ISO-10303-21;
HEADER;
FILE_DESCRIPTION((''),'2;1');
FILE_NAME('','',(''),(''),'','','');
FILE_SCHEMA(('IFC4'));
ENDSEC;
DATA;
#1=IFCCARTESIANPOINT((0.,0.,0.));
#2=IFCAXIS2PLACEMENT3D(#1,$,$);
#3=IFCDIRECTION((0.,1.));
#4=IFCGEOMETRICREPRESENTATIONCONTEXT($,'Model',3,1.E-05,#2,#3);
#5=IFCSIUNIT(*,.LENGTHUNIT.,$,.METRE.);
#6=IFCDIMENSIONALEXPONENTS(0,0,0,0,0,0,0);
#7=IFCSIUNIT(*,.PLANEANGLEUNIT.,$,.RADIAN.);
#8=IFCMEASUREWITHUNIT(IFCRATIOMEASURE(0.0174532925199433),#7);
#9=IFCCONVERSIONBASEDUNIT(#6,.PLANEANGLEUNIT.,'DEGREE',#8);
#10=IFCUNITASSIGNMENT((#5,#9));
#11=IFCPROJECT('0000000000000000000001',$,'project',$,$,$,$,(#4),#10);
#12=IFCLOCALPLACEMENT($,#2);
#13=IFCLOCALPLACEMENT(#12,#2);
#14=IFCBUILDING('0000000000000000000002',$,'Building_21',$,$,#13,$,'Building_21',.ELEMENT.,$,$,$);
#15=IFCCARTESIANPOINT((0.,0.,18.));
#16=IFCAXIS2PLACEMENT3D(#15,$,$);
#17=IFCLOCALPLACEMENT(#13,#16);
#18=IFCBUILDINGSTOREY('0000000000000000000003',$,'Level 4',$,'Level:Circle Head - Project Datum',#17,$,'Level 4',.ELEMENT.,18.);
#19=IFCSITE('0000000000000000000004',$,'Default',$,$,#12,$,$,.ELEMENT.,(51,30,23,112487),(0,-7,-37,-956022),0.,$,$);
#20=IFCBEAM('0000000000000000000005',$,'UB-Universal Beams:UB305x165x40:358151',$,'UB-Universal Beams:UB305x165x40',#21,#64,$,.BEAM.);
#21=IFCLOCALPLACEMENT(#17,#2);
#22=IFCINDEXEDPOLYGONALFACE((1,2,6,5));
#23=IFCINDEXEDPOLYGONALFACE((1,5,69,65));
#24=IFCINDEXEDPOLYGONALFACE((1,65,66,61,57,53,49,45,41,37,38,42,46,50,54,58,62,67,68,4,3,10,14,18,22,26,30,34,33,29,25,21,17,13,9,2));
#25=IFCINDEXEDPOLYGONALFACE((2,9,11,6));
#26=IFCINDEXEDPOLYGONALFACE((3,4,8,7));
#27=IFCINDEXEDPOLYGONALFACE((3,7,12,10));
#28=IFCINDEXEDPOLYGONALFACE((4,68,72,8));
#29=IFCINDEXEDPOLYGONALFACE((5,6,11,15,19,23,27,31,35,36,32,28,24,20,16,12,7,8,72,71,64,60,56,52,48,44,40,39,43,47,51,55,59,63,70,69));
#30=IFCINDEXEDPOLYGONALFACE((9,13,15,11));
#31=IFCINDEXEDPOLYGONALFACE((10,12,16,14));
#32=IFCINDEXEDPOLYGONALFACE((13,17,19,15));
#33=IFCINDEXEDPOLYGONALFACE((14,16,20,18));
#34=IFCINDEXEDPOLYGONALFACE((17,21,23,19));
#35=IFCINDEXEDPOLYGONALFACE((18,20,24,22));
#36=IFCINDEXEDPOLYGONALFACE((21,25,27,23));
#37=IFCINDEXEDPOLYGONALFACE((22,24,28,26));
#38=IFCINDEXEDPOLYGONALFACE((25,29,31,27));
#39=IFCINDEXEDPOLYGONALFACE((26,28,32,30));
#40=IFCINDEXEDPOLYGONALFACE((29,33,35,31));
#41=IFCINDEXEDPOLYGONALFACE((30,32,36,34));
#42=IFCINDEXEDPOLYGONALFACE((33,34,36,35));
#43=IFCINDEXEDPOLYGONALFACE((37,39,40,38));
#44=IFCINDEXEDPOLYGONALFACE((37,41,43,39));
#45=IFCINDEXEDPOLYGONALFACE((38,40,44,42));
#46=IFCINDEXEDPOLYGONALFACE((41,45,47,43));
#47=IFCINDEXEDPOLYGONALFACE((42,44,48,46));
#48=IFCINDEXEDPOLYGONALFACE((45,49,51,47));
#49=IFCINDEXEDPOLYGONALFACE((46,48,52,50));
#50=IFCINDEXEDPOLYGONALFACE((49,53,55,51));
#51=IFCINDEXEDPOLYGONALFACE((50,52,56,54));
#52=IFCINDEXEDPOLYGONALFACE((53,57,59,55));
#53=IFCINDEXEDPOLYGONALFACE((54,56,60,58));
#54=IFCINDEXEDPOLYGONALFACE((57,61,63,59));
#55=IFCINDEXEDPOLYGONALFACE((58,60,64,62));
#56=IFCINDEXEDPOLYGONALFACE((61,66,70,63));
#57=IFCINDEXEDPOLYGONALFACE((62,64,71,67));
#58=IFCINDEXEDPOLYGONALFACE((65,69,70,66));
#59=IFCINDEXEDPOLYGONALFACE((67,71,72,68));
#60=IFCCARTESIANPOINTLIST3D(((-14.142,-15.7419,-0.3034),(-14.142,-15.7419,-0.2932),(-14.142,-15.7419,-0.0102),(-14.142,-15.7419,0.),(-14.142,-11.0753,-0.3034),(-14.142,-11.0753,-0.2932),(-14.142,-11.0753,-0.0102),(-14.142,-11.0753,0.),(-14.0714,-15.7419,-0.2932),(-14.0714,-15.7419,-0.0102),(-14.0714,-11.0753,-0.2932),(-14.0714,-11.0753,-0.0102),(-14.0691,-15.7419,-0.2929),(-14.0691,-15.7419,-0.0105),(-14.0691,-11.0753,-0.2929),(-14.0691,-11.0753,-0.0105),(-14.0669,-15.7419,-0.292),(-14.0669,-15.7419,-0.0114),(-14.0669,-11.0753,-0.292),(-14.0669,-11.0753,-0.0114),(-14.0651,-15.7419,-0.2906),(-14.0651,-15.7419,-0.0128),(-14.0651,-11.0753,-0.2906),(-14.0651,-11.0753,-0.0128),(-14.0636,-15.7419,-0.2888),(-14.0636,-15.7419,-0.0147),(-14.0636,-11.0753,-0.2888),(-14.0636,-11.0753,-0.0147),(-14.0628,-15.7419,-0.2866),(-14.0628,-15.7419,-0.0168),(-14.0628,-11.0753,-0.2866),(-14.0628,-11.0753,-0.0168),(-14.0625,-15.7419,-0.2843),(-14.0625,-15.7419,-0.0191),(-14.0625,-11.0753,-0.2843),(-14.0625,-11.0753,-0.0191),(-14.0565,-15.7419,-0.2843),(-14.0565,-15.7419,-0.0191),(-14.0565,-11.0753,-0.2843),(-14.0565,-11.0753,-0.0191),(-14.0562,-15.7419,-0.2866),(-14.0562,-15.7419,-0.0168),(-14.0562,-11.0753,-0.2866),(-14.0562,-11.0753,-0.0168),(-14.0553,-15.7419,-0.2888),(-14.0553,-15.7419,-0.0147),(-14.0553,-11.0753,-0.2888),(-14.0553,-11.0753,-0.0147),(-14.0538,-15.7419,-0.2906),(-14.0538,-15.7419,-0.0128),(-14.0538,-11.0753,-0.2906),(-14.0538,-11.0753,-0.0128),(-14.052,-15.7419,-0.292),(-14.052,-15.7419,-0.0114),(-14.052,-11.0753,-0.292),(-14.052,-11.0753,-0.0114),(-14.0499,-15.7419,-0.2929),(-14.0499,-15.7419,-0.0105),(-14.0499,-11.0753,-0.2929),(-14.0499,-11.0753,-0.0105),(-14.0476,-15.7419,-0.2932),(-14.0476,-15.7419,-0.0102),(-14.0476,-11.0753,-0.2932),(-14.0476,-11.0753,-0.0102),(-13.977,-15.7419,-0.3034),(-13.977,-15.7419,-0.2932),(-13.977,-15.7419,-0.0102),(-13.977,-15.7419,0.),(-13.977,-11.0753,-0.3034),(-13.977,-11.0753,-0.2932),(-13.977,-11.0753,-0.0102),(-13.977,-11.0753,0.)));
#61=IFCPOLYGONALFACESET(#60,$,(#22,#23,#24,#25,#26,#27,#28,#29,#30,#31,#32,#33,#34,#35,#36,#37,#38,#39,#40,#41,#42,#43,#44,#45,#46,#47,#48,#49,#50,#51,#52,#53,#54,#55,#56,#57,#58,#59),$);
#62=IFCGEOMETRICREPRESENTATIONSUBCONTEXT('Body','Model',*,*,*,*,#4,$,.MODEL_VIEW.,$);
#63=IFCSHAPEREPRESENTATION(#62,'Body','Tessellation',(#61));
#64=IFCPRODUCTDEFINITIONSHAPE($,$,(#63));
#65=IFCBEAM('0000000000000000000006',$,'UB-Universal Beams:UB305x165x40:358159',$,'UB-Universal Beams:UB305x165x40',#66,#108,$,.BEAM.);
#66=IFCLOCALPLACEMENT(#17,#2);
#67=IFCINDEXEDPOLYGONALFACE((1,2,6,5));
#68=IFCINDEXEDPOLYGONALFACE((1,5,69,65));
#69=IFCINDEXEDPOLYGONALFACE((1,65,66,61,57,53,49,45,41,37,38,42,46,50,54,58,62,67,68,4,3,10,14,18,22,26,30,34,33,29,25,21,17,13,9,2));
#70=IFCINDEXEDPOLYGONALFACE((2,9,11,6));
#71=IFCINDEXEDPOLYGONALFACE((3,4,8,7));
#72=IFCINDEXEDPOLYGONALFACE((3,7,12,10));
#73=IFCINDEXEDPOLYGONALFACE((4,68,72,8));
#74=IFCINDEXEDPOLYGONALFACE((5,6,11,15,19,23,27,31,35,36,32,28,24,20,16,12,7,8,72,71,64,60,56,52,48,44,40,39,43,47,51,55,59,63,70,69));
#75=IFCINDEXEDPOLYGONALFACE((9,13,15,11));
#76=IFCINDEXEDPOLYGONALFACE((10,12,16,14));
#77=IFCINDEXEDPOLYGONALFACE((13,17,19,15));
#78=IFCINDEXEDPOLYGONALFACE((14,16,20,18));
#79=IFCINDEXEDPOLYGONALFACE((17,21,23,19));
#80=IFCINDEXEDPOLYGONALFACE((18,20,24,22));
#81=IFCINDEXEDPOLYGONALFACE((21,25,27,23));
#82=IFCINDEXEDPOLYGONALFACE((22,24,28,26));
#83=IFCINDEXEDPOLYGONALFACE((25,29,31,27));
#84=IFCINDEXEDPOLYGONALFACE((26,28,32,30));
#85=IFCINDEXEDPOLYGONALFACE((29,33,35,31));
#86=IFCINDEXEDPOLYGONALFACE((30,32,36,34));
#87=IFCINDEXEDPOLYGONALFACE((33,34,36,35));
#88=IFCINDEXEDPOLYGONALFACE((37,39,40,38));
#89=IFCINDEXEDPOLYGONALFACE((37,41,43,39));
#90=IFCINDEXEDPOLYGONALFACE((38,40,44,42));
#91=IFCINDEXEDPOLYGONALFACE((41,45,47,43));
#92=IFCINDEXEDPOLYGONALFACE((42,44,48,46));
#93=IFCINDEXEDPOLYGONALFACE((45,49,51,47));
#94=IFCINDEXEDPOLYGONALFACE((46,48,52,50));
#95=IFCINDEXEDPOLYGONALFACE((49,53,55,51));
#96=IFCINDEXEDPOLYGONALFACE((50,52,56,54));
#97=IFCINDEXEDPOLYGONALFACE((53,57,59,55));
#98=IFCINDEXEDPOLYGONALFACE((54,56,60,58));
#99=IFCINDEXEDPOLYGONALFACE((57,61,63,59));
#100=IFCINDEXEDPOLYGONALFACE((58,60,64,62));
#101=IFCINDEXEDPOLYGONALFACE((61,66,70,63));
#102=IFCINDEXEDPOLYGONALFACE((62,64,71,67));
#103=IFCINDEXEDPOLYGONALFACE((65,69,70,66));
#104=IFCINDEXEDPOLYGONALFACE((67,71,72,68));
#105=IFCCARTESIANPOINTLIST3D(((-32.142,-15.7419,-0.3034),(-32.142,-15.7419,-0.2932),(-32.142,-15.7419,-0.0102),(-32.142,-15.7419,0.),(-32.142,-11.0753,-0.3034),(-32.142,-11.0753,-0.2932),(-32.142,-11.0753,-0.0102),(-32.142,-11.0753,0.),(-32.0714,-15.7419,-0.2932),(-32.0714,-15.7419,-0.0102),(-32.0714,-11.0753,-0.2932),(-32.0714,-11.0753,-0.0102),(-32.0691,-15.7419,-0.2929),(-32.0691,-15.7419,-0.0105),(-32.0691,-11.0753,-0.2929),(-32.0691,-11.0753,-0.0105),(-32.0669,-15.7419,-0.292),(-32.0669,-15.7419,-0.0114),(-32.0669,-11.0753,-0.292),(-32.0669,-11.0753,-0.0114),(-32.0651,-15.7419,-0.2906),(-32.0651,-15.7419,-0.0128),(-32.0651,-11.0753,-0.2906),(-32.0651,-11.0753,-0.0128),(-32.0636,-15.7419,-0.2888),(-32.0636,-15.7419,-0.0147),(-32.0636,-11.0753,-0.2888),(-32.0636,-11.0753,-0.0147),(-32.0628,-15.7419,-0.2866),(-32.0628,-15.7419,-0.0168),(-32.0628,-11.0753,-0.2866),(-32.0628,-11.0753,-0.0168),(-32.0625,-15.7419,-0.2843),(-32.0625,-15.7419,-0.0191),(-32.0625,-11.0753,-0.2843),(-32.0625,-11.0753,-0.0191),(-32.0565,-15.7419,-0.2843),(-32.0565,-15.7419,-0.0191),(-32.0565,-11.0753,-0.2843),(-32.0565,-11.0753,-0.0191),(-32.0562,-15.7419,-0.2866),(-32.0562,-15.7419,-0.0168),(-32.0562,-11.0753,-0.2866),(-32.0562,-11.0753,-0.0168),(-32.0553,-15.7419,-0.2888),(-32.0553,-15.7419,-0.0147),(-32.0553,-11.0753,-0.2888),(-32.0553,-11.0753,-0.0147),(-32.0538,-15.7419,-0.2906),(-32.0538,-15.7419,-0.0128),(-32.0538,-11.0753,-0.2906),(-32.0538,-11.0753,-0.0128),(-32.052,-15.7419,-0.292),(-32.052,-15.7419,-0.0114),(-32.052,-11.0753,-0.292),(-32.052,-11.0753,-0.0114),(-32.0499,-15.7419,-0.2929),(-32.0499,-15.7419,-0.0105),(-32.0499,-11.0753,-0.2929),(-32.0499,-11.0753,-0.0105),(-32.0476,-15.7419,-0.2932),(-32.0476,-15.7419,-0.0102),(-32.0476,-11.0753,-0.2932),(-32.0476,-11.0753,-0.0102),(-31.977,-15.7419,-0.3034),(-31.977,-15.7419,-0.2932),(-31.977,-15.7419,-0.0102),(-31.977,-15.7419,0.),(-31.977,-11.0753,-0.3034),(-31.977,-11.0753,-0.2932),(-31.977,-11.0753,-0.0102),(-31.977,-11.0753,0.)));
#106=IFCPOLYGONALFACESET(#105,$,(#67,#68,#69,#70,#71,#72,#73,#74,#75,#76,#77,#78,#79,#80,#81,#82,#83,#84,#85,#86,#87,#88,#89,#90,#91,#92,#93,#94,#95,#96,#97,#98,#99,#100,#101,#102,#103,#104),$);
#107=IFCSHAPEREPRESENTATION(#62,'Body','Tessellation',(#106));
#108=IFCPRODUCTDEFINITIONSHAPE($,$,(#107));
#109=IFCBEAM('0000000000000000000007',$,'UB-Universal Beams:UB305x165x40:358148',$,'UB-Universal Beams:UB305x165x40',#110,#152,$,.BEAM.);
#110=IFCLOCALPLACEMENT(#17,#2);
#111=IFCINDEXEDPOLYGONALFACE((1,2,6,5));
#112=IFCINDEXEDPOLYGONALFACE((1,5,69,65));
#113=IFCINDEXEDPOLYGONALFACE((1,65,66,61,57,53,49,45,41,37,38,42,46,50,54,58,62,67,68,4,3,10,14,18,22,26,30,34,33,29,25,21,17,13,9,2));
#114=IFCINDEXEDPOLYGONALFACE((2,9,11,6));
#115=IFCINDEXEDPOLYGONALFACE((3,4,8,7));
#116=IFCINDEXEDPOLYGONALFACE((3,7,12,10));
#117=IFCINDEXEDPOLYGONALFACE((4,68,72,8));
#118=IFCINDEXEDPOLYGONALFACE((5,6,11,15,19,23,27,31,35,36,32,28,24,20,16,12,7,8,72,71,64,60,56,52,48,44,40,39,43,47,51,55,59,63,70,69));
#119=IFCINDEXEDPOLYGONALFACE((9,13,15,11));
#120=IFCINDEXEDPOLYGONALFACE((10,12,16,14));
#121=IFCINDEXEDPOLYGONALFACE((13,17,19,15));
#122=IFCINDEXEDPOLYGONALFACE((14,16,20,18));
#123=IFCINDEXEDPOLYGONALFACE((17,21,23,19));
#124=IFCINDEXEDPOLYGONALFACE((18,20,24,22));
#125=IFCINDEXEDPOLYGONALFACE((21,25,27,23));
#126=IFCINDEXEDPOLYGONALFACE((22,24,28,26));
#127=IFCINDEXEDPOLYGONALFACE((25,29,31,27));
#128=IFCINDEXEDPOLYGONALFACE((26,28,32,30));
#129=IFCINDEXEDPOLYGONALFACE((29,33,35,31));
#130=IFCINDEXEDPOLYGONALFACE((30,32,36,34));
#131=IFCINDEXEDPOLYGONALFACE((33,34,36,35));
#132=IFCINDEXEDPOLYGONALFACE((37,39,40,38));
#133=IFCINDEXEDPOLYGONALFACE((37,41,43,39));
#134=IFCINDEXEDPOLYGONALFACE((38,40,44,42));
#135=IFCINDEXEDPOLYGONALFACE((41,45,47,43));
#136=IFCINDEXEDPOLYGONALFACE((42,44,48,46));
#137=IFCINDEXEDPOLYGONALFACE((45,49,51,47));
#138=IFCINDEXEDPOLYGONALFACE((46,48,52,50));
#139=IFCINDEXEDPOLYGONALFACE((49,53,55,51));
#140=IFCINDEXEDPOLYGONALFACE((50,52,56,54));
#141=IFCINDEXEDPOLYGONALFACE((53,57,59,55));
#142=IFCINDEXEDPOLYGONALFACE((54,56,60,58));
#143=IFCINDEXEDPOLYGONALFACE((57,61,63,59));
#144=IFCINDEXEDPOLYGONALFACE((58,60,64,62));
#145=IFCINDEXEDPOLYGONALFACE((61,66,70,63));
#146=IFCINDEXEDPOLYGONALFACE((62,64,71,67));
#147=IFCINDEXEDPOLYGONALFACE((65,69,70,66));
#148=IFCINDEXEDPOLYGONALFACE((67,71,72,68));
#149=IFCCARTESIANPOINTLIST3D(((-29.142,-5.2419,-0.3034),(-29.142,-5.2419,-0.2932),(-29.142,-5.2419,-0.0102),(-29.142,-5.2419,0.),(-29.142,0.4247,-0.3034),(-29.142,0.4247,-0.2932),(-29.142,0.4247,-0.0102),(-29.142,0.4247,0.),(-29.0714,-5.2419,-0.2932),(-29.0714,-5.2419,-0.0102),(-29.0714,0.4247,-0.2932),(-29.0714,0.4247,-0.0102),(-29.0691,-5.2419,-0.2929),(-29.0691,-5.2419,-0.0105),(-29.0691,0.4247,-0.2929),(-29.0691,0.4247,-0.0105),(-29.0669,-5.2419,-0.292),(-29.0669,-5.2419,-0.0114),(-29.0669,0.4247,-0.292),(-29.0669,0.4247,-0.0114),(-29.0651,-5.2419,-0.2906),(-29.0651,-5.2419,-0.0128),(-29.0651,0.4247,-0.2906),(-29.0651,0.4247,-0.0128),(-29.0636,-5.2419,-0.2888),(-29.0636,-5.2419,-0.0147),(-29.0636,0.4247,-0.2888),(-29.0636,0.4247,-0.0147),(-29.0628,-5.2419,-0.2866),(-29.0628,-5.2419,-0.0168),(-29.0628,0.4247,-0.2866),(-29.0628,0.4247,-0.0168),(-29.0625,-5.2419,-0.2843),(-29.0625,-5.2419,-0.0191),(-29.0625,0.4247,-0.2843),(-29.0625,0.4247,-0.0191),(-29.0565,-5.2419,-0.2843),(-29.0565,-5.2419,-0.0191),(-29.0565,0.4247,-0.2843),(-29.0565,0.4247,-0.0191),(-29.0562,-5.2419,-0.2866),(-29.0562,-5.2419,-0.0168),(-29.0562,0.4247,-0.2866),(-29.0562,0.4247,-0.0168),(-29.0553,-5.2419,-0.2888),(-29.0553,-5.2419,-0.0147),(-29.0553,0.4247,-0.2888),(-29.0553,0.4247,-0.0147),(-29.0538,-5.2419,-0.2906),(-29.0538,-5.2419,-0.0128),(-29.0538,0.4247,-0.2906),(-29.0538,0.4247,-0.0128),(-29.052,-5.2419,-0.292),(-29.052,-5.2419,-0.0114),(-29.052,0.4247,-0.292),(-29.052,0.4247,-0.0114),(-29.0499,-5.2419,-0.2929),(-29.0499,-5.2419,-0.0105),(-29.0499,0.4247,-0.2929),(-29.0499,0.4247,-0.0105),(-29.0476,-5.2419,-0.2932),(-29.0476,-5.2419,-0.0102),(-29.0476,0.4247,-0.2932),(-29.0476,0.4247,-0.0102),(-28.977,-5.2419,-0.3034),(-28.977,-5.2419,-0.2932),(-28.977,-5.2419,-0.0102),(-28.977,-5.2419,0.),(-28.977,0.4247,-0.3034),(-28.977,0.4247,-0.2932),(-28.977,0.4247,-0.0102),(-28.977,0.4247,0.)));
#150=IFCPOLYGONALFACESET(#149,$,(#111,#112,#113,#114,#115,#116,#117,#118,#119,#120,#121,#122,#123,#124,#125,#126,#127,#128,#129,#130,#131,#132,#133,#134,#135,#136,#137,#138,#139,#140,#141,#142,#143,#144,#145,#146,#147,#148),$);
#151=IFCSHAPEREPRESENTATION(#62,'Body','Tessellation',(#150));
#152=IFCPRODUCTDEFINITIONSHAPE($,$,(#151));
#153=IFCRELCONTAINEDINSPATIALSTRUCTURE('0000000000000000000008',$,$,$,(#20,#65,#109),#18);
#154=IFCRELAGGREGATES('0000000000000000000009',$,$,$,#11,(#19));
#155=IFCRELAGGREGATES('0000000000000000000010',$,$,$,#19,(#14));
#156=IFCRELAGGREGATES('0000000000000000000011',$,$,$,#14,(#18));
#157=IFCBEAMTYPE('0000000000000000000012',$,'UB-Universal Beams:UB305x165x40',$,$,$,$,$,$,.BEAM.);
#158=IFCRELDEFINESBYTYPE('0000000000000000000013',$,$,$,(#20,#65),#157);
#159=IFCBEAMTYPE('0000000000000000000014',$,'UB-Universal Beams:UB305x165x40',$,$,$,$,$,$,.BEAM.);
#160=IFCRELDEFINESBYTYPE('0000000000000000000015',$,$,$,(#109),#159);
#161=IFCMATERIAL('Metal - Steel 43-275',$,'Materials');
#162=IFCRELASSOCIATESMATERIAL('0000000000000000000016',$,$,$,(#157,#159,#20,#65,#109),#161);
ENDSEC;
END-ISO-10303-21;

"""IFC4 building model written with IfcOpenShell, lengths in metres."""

from ifc_helpers import new_model, entity, si_unit, converted_unit, direction, frame, frame_2d, origin, place, context, subcontext, project, spatial, polyline, circle_curve, parameter, trimmed, segment, composite_curve, i_section, outline, extrude, source, transform, mapped, material, material_profile, profile_set, profile_usage, type_object, type_shapes, element, save


model = new_model("IFC4")

# Units and contexts
model_context = context("Model", 3, precision=1e-05, world=origin(), true_north=direction((0.0, 1.0)))
body_context = subcontext(model_context, "Body", "Model", "MODEL_VIEW")
ifc_project = project(units=[si_unit("LENGTHUNIT", "METRE"), converted_unit("PLANEANGLEUNIT", "DEGREE", entity("IfcRatioMeasure", 0.0174532925199433), si_unit("PLANEANGLEUNIT", "RADIAN"), dimensions=[0, 0, 0, 0, 0, 0, 0])], contexts=[model_context])

# Site, building, storey
site_placement = place(None, origin())
site = spatial("IfcSite", under=ifc_project, at=site_placement, Name="Default", CompositionType="ELEMENT", RefLatitude=(51, 30, 23, 112487), RefLongitude=(0, -7, -37, -956022), RefElevation=0.0)
building_placement = place(site_placement, origin())
building = spatial("IfcBuilding", under=site, at=building_placement, Name="Building_21", LongName="Building_21", CompositionType="ELEMENT")
storey_placement = place(building_placement, frame((0.0, 0.0, 18.0)))
storey = spatial("IfcBuildingStorey", under=building, at=storey_placement, Name="Level 4", ObjectType="Level:Circle Head - Project Datum", LongName="Level 4", CompositionType="ELEMENT", Elevation=18.0)

# Beams
ifc_material_1 = material(Name="Metal - Steel 43-275", Category="Materials")
ifc_material_profile_1 = material_profile(ifc_material_1, outline(composite_curve([segment(polyline([(0.0119, -0.1415, 0.0), (0.0825, -0.1415, 0.0)]), True, "CONTINUOUS"), segment(polyline([(0.0825, -0.1415, 0.0), (0.0825, -0.1517, 0.0)]), True, "CONTINUOUS"), segment(polyline([(0.0825, -0.1517, 0.0), (-0.0825, -0.1517, 0.0)]), True, "CONTINUOUS"), segment(polyline([(-0.0825, -0.1517, 0.0), (-0.0825, -0.1415, 0.0)]), True, "CONTINUOUS"), segment(polyline([(-0.0825, -0.1415, 0.0), (-0.0119, -0.1415, 0.0)]), True, "CONTINUOUS"), segment(trimmed(circle_curve(frame((-0.0119, -0.1326, 0.0), z_axis=(0.0, 0.0, 1.0), x_axis=(-1.0, 0.0, 0.0)), 0.0089), [parameter(90.0)], [parameter(180.0)], True, "PARAMETER"), True, "CONTINUOUS"), segment(polyline([(-0.003, -0.1326, 0.0), (-0.003, 0.1326, 0.0)]), True, "CONTINUOUS"), segment(trimmed(circle_curve(frame((-0.0119, 0.1326, 0.0), z_axis=(0.0, 0.0, 1.0), x_axis=(-1.0, 0.0, 0.0)), 0.0089), [parameter(180.0)], [parameter(270.0)], True, "PARAMETER"), True, "CONTINUOUS"), segment(polyline([(-0.0119, 0.1415, 0.0), (-0.0825, 0.1415, 0.0)]), True, "CONTINUOUS"), segment(polyline([(-0.0825, 0.1415, 0.0), (-0.0825, 0.1517, 0.0)]), True, "CONTINUOUS"), segment(polyline([(-0.0825, 0.1517, 0.0), (0.0825, 0.1517, 0.0)]), True, "CONTINUOUS"), segment(polyline([(0.0825, 0.1517, 0.0), (0.0825, 0.1415, 0.0)]), True, "CONTINUOUS"), segment(polyline([(0.0825, 0.1415, 0.0), (0.0119, 0.1415, 0.0)]), True, "CONTINUOUS"), segment(trimmed(circle_curve(frame((0.0119, 0.1326, 0.0), z_axis=(0.0, 0.0, 1.0), x_axis=(-1.0, 0.0, 0.0)), 0.0089), [parameter(270.0)], [parameter(0.0)], True, "PARAMETER"), True, "CONTINUOUS"), segment(polyline([(0.003, 0.1326, 0.0), (0.003, -0.1326, 0.0)]), True, "CONTINUOUS"), segment(trimmed(circle_curve(frame((0.0119, -0.1326, 0.0), z_axis=(0.0, 0.0, 1.0), x_axis=(-1.0, 0.0, 0.0)), 0.0089), [parameter(0.0)], [parameter(90.0)], True, "PARAMETER"), True, "CONTINUOUS")], self_intersect=False), kind="CURVE"), Name="UB305x165x40")
ifc_material_profile_2 = material_profile(ifc_material_1, outline(composite_curve([segment(polyline([(-1.3346, 0.0825, -0.1415), (-1.3346, 0.0825, -0.1517)]), True, "CONTINUOUS"), segment(polyline([(-1.3346, 0.0825, -0.1517), (-1.3346, -0.0825, -0.1517)]), True, "CONTINUOUS"), segment(polyline([(-1.3346, -0.0825, -0.1517), (-1.3346, -0.0825, -0.1415)]), True, "CONTINUOUS"), segment(polyline([(-1.3346, -0.0825, -0.1415), (-1.3346, -0.003, -0.1415)]), True, "CONTINUOUS"), segment(polyline([(-1.3346, -0.003, -0.1415), (-1.3346, -0.003, 0.1415)]), True, "CONTINUOUS"), segment(polyline([(-1.3346, -0.003, 0.1415), (-1.3346, -0.0825, 0.1415)]), True, "CONTINUOUS"), segment(polyline([(-1.3346, -0.0825, 0.1415), (-1.3346, -0.0825, 0.1517)]), True, "CONTINUOUS"), segment(polyline([(-1.3346, -0.0825, 0.1517), (-1.3346, 0.0825, 0.1517)]), True, "CONTINUOUS"), segment(polyline([(-1.3346, 0.0825, 0.1517), (-1.3346, 0.0825, 0.1415)]), True, "CONTINUOUS"), segment(polyline([(-1.3346, 0.0825, 0.1415), (-1.3346, 0.003, 0.1415)]), True, "CONTINUOUS"), segment(polyline([(-1.3346, 0.003, 0.1415), (-1.3346, 0.003, -0.1415)]), True, "CONTINUOUS"), segment(polyline([(-1.3346, 0.003, -0.1415), (-1.3346, 0.0825, -0.1415)]), True, "CONTINUOUS")], self_intersect=False), kind="CURVE"), Name="UB305x165x40")
ifc_profile_set = profile_set([ifc_material_profile_1, ifc_material_profile_2], Name="UB305x165x40")
beam_type_1 = type_object("IfcBeamType", Name="UB-Universal Beams:UB305x165x40", PredefinedType="BEAM", material=ifc_profile_set)
shared_shape_1 = source(origin(), body_context, "Body", "SweptSolid", [
    extrude(i_section(OverallWidth=0.165, OverallDepth=0.3034, WebThickness=0.006, FlangeThickness=0.0102, FilletRadius=0.0089, at=frame_2d((0.0, 0.0), x_axis=(0.0, 1.0))), frame((-2.3333, 0.0, 0.0), z_axis=(1.0, 0.0, 0.0), x_axis=(0.0, 0.0, -1.0)), (0.0, 0.0, 1.0), 4.6666),
])
type_shapes(beam_type_1, [shared_shape_1])
ifc_profile_usage_1 = profile_usage(ifc_profile_set, cardinal=8)
beam_1_placement = place(storey_placement, frame((-14.0595, -13.4086, -0.1517), z_axis=(0.0, 0.0, 1.0), x_axis=(0.0, 1.0, 0.0)))
element("IfcBeam", 1, at=beam_1_placement, inside=storey, type_object=beam_type_1, material=ifc_profile_usage_1, Name="UB-Universal Beams:UB305x165x40:358151", ObjectType="UB-Universal Beams:UB305x165x40", PredefinedType="BEAM", context=body_context, shape_type="MappedRepresentation", body=[
    mapped(shared_shape_1, transform((0.0, 0.0, 0.0), scale=1.0)),
])
ifc_profile_usage_2 = profile_usage(ifc_profile_set, cardinal=8)
beam_2_placement = place(storey_placement, frame((-32.0595, -13.4086, -0.1517), z_axis=(0.0, 0.0, 1.0), x_axis=(0.0, -1.0, 0.0)))
element("IfcBeam", 2, at=beam_2_placement, inside=storey, type_object=beam_type_1, material=ifc_profile_usage_2, Name="UB-Universal Beams:UB305x165x40:358159", ObjectType="UB-Universal Beams:UB305x165x40", PredefinedType="BEAM", context=body_context, shape_type="MappedRepresentation", body=[
    mapped(shared_shape_1, transform((0.0, 0.0, 0.0), scale=1.0)),
])
ifc_profile_usage_3 = profile_usage(ifc_profile_set, cardinal=8)
beam_type_2 = type_object("IfcBeamType", Name="UB-Universal Beams:UB305x165x40", PredefinedType="BEAM", material=ifc_profile_set)
shared_shape_2 = source(origin(), body_context, "Body", "SweptSolid", [
    extrude(i_section(OverallWidth=0.165, OverallDepth=0.3034, WebThickness=0.006, FlangeThickness=0.0102, FilletRadius=0.0089, at=frame_2d((0.0, 0.0), x_axis=(0.0, 1.0))), frame((-2.8333, 0.0, 0.0), z_axis=(1.0, 0.0, 0.0), x_axis=(0.0, 0.0, -1.0)), (0.0, 0.0, 1.0), 5.6666),
])
type_shapes(beam_type_2, [shared_shape_2])
beam_3_placement = place(storey_placement, frame((-29.0595, -2.4086, -0.1517), z_axis=(0.0, 0.0, 1.0), x_axis=(0.0, 1.0, 0.0)))
element("IfcBeam", 3, at=beam_3_placement, inside=storey, type_object=beam_type_2, material=ifc_profile_usage_3, Name="UB-Universal Beams:UB305x165x40:358148", ObjectType="UB-Universal Beams:UB305x165x40", PredefinedType="BEAM", context=body_context, shape_type="MappedRepresentation", body=[
    mapped(shared_shape_2, transform((0.0, 0.0, 0.0), scale=1.0)),
])

save(model, "model.ifc")
